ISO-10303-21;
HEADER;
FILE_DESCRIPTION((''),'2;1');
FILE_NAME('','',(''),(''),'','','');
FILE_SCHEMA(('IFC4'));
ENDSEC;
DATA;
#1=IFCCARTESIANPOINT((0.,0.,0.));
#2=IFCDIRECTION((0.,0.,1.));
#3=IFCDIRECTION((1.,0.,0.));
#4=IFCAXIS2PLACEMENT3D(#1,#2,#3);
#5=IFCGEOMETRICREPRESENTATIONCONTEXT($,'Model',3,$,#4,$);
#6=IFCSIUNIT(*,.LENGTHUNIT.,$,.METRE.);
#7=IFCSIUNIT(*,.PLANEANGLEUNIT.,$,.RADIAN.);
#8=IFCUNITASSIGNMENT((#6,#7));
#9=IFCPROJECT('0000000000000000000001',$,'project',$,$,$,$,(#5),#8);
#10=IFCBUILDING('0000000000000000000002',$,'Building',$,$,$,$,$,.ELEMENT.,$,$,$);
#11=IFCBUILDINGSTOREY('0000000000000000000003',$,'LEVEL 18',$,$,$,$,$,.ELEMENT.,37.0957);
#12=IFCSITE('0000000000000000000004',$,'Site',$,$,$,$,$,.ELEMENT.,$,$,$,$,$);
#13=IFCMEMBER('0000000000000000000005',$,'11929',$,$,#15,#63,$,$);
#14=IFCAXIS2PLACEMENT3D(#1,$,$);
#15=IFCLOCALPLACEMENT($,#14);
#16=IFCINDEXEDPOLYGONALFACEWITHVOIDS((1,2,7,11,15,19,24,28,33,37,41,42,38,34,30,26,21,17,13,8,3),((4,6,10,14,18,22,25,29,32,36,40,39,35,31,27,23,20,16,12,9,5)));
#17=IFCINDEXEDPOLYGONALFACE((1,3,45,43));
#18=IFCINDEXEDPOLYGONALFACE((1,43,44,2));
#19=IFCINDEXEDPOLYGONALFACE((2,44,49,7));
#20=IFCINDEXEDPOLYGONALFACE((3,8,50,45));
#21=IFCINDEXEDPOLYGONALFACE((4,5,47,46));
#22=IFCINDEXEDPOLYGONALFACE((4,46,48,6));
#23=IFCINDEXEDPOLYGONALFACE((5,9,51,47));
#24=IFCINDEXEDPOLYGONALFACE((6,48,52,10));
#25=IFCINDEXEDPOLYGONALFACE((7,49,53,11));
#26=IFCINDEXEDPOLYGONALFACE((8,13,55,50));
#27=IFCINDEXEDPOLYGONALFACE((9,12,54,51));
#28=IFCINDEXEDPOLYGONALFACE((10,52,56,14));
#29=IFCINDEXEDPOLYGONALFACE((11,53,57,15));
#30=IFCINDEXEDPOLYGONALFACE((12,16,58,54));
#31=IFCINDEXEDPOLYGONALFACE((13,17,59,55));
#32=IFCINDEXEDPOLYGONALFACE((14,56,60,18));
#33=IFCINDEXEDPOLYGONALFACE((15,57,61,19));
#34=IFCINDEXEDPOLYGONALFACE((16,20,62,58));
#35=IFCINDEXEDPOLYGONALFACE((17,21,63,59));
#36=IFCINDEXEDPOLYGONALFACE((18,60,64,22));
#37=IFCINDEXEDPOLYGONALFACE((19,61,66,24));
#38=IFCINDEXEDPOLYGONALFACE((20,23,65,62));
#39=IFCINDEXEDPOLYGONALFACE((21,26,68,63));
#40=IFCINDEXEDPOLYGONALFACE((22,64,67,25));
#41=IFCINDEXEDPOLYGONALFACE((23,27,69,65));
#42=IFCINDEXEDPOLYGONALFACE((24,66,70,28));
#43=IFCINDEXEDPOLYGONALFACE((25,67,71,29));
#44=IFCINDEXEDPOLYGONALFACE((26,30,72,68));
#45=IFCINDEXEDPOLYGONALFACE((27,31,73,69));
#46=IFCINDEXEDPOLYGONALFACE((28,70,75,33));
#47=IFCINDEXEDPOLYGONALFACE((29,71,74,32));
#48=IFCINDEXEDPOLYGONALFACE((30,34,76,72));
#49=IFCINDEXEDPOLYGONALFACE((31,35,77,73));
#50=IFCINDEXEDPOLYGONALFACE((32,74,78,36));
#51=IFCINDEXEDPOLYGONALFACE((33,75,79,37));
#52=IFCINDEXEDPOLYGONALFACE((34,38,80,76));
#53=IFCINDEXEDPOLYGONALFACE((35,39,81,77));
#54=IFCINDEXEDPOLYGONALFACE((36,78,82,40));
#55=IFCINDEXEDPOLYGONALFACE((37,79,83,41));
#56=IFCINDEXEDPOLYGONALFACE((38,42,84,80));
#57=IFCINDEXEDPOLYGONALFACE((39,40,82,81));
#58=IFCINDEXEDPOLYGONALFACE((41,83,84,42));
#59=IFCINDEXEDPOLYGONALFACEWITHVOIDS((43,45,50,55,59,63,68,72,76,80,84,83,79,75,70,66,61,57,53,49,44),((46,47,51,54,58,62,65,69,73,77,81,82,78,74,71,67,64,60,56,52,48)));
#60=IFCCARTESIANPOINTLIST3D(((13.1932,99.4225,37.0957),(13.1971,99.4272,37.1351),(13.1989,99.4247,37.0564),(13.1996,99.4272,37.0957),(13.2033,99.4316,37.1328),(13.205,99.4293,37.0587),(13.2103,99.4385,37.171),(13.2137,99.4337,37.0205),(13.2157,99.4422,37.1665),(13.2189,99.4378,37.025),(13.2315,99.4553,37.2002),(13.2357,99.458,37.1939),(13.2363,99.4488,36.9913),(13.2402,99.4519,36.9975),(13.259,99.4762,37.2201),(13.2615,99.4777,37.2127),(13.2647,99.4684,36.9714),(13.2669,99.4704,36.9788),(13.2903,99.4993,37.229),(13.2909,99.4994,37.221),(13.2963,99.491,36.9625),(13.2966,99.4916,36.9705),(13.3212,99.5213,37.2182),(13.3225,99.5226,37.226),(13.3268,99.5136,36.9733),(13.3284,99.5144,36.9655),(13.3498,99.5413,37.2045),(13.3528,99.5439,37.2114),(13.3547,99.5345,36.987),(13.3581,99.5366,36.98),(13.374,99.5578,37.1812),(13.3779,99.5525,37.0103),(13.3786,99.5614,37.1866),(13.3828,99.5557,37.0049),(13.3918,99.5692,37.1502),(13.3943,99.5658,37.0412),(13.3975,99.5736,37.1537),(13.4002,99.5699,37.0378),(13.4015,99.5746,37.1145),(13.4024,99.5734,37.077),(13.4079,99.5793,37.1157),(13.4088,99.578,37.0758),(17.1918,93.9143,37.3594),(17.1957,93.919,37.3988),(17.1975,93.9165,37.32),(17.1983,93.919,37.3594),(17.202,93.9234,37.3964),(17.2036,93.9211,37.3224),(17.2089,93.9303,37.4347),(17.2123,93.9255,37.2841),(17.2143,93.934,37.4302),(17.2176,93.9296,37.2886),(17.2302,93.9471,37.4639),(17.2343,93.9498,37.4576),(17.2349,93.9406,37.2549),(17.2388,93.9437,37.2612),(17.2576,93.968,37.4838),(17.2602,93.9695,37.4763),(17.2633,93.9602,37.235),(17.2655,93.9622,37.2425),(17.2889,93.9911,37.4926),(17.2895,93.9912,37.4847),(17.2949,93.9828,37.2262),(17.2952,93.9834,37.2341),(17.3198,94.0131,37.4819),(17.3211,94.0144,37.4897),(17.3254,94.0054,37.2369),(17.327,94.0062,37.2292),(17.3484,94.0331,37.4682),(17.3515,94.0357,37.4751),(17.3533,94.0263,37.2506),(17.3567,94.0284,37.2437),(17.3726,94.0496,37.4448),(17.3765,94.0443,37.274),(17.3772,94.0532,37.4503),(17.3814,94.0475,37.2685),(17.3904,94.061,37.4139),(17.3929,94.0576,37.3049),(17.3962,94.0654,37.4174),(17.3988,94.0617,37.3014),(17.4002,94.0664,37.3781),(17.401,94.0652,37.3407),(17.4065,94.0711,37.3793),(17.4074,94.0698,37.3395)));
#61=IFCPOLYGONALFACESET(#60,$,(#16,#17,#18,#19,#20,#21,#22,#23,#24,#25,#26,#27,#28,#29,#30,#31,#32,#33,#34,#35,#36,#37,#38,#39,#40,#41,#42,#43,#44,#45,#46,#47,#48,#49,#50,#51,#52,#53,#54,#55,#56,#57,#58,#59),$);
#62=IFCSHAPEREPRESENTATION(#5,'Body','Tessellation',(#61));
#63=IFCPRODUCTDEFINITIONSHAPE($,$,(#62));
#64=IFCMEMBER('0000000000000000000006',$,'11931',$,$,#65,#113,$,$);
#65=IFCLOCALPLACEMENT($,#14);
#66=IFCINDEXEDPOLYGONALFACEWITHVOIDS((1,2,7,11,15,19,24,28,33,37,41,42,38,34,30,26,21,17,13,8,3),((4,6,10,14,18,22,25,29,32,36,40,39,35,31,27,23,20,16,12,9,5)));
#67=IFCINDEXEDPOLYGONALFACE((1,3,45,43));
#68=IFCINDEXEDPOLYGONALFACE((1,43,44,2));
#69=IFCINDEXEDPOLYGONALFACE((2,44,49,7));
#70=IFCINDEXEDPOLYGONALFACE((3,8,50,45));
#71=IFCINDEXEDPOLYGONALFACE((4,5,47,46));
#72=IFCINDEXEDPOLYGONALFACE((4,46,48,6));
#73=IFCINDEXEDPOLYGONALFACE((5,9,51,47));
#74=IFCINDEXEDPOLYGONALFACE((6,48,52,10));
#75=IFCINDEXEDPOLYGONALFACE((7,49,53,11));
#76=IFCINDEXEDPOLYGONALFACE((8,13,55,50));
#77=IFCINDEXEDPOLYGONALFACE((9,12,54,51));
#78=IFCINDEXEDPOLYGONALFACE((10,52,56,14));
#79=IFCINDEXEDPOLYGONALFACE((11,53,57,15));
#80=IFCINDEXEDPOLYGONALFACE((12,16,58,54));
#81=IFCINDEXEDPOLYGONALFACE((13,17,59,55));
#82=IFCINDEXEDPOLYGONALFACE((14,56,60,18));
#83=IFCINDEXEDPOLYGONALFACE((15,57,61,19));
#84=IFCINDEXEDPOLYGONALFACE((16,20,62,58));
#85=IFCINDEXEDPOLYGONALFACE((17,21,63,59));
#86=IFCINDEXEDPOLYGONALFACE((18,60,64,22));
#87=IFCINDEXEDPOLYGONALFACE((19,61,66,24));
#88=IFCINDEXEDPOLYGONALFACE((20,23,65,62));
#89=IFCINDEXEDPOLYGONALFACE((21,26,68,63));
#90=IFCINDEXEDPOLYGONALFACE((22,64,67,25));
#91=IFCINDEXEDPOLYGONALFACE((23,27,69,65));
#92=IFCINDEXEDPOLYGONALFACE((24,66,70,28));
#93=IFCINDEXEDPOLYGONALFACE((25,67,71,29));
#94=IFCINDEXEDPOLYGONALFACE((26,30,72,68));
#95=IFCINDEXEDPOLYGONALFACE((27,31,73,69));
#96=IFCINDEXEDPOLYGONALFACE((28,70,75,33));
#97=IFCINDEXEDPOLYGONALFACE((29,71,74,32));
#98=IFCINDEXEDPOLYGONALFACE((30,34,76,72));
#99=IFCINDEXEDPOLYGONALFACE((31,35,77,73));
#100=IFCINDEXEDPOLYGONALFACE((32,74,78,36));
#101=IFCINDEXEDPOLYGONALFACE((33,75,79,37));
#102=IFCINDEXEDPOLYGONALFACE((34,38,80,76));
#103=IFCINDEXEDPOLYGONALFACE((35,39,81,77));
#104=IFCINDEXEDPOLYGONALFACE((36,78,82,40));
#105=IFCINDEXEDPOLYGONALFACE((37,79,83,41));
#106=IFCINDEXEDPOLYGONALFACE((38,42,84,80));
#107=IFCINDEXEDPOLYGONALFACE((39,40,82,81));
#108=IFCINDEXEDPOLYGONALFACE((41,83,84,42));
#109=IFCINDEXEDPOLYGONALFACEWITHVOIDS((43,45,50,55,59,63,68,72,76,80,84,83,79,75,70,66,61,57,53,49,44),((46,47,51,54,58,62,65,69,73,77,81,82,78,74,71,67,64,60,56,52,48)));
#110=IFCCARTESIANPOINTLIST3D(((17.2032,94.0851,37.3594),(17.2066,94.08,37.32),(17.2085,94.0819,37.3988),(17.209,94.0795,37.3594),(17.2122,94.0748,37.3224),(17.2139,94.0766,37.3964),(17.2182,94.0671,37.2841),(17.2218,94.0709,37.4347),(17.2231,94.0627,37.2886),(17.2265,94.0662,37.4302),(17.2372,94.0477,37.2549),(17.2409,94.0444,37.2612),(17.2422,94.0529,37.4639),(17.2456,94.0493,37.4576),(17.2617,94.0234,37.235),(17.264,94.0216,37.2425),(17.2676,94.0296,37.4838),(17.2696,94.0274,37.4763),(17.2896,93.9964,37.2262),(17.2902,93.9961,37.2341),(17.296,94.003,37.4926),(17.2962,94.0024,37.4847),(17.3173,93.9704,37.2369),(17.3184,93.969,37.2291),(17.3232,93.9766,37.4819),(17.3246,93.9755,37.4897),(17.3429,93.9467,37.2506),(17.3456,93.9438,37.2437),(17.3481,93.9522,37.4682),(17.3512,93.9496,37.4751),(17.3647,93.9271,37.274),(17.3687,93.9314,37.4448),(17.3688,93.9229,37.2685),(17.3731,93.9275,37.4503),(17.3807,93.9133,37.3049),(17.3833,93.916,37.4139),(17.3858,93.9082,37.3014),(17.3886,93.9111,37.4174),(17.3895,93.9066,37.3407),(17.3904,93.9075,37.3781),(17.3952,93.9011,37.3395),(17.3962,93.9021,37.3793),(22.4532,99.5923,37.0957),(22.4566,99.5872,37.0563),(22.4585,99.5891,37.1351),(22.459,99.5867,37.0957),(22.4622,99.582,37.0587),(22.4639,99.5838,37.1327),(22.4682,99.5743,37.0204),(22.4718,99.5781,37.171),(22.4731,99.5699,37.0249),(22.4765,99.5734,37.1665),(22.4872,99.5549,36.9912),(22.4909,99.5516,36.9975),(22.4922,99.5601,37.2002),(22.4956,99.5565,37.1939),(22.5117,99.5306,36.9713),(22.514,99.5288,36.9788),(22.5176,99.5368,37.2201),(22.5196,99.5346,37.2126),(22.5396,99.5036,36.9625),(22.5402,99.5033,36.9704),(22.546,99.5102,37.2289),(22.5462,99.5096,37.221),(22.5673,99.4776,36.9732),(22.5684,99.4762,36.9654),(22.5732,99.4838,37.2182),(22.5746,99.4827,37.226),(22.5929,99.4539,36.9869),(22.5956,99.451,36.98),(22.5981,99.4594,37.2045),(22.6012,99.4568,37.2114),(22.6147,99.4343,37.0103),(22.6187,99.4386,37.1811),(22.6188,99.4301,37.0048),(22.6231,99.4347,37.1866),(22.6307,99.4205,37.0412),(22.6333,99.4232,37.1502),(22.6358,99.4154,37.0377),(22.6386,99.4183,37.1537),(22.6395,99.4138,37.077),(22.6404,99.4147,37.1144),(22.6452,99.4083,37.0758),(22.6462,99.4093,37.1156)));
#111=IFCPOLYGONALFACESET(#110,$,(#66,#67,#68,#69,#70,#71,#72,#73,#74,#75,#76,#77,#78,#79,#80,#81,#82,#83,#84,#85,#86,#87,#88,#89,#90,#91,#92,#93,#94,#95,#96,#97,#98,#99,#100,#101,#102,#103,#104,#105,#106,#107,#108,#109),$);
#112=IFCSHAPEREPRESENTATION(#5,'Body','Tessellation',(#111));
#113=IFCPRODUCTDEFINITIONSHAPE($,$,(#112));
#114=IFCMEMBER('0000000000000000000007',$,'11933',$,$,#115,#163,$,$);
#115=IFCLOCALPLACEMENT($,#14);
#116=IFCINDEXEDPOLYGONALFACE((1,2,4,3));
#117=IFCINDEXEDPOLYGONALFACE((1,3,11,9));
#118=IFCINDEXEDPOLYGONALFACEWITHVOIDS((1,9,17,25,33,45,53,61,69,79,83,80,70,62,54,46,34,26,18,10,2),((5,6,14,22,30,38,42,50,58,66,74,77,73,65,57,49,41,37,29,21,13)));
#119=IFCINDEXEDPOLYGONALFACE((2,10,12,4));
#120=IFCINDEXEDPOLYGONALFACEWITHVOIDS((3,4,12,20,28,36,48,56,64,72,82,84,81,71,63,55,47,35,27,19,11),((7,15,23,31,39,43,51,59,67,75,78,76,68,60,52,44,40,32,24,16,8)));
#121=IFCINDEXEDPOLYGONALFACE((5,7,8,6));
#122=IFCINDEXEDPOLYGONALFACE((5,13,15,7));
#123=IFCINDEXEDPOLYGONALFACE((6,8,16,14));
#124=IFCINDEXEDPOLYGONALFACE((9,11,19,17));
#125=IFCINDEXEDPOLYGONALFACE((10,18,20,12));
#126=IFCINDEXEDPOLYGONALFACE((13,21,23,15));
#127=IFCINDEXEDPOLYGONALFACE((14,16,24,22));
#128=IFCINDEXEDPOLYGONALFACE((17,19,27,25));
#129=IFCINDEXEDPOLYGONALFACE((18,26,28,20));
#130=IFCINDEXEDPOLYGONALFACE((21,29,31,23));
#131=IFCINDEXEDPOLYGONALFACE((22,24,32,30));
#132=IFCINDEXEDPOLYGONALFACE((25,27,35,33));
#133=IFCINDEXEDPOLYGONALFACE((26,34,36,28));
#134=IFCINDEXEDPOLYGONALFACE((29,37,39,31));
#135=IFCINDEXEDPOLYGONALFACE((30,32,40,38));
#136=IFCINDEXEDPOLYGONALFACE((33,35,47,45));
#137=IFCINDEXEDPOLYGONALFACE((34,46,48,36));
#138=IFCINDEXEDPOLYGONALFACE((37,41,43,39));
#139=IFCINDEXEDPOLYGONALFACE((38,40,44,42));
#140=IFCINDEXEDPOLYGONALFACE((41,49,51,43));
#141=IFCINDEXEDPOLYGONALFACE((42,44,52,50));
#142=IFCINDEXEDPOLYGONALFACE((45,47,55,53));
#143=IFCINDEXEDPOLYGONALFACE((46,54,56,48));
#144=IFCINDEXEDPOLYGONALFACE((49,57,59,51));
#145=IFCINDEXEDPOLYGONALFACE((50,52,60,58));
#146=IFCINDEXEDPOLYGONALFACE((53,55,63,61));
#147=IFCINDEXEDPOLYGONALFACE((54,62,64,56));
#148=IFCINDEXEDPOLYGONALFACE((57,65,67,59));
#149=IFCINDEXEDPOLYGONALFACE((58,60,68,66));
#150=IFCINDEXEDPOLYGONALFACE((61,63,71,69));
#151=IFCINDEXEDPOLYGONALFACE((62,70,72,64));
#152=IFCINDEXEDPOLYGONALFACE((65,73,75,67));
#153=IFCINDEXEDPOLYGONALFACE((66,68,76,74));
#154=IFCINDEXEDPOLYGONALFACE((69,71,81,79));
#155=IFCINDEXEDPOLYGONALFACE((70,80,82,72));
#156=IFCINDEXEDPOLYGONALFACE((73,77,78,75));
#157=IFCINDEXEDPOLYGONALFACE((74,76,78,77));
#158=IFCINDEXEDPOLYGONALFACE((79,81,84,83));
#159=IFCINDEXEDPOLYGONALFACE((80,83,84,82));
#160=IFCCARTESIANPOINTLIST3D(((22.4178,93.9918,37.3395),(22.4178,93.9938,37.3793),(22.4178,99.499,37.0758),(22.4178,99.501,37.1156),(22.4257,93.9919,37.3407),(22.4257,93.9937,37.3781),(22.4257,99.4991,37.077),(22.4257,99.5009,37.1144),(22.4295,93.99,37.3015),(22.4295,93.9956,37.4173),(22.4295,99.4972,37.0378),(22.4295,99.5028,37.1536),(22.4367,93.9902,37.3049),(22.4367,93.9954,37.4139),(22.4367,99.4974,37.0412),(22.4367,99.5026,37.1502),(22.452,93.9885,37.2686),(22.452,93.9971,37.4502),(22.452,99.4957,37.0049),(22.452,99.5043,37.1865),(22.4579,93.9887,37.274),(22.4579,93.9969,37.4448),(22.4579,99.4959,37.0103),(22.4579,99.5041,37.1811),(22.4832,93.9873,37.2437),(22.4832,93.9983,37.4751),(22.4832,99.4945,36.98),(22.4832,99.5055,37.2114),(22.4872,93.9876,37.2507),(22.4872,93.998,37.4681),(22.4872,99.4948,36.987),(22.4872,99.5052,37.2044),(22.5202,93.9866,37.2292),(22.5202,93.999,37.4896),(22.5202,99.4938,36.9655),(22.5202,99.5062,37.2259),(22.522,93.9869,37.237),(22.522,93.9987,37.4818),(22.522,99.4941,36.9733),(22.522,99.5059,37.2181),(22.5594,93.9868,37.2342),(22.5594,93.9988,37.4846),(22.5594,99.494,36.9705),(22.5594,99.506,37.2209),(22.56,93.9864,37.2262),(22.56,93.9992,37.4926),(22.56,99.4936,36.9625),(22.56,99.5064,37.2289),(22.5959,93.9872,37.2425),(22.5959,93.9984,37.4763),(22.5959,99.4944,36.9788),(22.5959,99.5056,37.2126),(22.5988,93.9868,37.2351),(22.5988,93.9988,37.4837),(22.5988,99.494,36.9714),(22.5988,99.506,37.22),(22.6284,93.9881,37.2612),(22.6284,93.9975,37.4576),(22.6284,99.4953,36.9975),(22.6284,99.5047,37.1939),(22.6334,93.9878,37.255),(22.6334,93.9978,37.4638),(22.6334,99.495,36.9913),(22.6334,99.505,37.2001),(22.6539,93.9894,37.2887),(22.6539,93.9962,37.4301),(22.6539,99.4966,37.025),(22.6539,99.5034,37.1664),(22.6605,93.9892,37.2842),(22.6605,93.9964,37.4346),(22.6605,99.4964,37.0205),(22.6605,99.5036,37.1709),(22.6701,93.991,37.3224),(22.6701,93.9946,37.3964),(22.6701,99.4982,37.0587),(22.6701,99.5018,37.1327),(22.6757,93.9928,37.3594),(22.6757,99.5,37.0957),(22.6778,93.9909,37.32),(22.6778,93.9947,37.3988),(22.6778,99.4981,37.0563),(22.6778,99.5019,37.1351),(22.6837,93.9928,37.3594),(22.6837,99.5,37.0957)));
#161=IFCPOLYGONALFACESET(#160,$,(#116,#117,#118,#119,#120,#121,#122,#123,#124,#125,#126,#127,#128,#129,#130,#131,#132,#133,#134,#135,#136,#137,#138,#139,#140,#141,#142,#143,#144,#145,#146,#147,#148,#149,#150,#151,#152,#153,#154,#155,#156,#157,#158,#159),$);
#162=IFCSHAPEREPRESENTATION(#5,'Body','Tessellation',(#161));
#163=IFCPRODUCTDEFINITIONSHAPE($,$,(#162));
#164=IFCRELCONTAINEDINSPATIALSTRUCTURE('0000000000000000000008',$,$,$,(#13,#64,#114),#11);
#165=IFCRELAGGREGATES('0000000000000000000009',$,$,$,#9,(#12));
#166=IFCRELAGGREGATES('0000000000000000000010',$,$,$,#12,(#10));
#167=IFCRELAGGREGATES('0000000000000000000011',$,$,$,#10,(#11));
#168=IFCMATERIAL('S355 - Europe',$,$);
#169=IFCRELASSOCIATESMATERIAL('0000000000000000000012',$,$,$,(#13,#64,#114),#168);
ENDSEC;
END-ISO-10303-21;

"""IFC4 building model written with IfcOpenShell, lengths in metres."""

from ifc_helpers import new_model, si_unit, frame, origin_with_axes, origin_2d_with_axis, place, context, project, spatial, hollow_circle, extrude, material, material_profile, profile_set, profile_usage, element, save


model = new_model("IFC4")

# Units and contexts
model_context = context("Model", 3, world=origin_with_axes())
ifc_project = project(units=[si_unit("LENGTHUNIT", "METRE"), si_unit("PLANEANGLEUNIT", "RADIAN")], contexts=[model_context])

# Site, building, storey
site = spatial("IfcSite", under=ifc_project, Name="Site", CompositionType="ELEMENT")
building = spatial("IfcBuilding", under=site, Name="Building", CompositionType="ELEMENT")
storey = spatial("IfcBuildingStorey", under=building, Name="LEVEL 18", CompositionType="ELEMENT", Elevation=37.0957)

# Shared definitions
ifc_material = material(Name="S355 - Europe")

# Members
ifc_material_profile_1 = material_profile(ifc_material, hollow_circle(Radius=0.1337, WallThickness=0.008, at=origin_2d_with_axis()))
ifc_profile_set_1 = profile_set([ifc_material_profile_1])
ifc_profile_usage_1 = profile_usage(ifc_profile_set_1, cardinal=10)
member_1_placement = place(None, frame((17.3, 93.9928, 37.3594), z_axis=(-0.587027, 0.808642, -0.038707), x_axis=(-0.809096, -0.587676, 0.0)))
element("IfcMember", 1, at=member_1_placement, inside=storey, material=ifc_profile_usage_1, Name="11929", context=model_context, shape_type="SweptSolid", body=[
    extrude(hollow_circle(Radius=0.1337, WallThickness=0.008, at=origin_2d_with_axis()), origin_with_axes(), (0.0, 0.0, 1.0), 6.8117),
])
ifc_material_profile_2 = material_profile(ifc_material, hollow_circle(Radius=0.1337, WallThickness=0.008, at=origin_2d_with_axis()))
ifc_profile_set_2 = profile_set([ifc_material_profile_2])
ifc_profile_usage_2 = profile_usage(ifc_profile_set_2, cardinal=10)
member_2_placement = place(None, frame((17.3, 93.9928, 37.3594), z_axis=(0.689589, 0.723372, -0.034637), x_axis=(-0.723807, 0.690003, 0.0)))
element("IfcMember", 2, at=member_2_placement, inside=storey, material=ifc_profile_usage_2, Name="11931", context=model_context, shape_type="SweptSolid", body=[
    extrude(hollow_circle(Radius=0.1337, WallThickness=0.008, at=origin_2d_with_axis()), origin_with_axes(), (0.0, 0.0, 1.0), 7.6132),
])
ifc_material_profile_3 = material_profile(ifc_material, hollow_circle(Radius=0.1337, WallThickness=0.008, at=origin_2d_with_axis()))
ifc_profile_set_3 = profile_set([ifc_material_profile_3])
ifc_profile_usage_3 = profile_usage(ifc_profile_set_3, cardinal=10)
member_3_placement = place(None, frame((22.55, 99.5, 37.0957), z_axis=(0.0, -0.998856, 0.047828), x_axis=(1.0, 0.0, 0.0)))
element("IfcMember", 3, at=member_3_placement, inside=storey, material=ifc_profile_usage_3, Name="11933", context=model_context, shape_type="SweptSolid", body=[
    extrude(hollow_circle(Radius=0.1337, WallThickness=0.008, at=origin_2d_with_axis()), origin_with_axes(), (0.0, 0.0, 1.0), 5.5135),
])

save(model, "model.ifc")
